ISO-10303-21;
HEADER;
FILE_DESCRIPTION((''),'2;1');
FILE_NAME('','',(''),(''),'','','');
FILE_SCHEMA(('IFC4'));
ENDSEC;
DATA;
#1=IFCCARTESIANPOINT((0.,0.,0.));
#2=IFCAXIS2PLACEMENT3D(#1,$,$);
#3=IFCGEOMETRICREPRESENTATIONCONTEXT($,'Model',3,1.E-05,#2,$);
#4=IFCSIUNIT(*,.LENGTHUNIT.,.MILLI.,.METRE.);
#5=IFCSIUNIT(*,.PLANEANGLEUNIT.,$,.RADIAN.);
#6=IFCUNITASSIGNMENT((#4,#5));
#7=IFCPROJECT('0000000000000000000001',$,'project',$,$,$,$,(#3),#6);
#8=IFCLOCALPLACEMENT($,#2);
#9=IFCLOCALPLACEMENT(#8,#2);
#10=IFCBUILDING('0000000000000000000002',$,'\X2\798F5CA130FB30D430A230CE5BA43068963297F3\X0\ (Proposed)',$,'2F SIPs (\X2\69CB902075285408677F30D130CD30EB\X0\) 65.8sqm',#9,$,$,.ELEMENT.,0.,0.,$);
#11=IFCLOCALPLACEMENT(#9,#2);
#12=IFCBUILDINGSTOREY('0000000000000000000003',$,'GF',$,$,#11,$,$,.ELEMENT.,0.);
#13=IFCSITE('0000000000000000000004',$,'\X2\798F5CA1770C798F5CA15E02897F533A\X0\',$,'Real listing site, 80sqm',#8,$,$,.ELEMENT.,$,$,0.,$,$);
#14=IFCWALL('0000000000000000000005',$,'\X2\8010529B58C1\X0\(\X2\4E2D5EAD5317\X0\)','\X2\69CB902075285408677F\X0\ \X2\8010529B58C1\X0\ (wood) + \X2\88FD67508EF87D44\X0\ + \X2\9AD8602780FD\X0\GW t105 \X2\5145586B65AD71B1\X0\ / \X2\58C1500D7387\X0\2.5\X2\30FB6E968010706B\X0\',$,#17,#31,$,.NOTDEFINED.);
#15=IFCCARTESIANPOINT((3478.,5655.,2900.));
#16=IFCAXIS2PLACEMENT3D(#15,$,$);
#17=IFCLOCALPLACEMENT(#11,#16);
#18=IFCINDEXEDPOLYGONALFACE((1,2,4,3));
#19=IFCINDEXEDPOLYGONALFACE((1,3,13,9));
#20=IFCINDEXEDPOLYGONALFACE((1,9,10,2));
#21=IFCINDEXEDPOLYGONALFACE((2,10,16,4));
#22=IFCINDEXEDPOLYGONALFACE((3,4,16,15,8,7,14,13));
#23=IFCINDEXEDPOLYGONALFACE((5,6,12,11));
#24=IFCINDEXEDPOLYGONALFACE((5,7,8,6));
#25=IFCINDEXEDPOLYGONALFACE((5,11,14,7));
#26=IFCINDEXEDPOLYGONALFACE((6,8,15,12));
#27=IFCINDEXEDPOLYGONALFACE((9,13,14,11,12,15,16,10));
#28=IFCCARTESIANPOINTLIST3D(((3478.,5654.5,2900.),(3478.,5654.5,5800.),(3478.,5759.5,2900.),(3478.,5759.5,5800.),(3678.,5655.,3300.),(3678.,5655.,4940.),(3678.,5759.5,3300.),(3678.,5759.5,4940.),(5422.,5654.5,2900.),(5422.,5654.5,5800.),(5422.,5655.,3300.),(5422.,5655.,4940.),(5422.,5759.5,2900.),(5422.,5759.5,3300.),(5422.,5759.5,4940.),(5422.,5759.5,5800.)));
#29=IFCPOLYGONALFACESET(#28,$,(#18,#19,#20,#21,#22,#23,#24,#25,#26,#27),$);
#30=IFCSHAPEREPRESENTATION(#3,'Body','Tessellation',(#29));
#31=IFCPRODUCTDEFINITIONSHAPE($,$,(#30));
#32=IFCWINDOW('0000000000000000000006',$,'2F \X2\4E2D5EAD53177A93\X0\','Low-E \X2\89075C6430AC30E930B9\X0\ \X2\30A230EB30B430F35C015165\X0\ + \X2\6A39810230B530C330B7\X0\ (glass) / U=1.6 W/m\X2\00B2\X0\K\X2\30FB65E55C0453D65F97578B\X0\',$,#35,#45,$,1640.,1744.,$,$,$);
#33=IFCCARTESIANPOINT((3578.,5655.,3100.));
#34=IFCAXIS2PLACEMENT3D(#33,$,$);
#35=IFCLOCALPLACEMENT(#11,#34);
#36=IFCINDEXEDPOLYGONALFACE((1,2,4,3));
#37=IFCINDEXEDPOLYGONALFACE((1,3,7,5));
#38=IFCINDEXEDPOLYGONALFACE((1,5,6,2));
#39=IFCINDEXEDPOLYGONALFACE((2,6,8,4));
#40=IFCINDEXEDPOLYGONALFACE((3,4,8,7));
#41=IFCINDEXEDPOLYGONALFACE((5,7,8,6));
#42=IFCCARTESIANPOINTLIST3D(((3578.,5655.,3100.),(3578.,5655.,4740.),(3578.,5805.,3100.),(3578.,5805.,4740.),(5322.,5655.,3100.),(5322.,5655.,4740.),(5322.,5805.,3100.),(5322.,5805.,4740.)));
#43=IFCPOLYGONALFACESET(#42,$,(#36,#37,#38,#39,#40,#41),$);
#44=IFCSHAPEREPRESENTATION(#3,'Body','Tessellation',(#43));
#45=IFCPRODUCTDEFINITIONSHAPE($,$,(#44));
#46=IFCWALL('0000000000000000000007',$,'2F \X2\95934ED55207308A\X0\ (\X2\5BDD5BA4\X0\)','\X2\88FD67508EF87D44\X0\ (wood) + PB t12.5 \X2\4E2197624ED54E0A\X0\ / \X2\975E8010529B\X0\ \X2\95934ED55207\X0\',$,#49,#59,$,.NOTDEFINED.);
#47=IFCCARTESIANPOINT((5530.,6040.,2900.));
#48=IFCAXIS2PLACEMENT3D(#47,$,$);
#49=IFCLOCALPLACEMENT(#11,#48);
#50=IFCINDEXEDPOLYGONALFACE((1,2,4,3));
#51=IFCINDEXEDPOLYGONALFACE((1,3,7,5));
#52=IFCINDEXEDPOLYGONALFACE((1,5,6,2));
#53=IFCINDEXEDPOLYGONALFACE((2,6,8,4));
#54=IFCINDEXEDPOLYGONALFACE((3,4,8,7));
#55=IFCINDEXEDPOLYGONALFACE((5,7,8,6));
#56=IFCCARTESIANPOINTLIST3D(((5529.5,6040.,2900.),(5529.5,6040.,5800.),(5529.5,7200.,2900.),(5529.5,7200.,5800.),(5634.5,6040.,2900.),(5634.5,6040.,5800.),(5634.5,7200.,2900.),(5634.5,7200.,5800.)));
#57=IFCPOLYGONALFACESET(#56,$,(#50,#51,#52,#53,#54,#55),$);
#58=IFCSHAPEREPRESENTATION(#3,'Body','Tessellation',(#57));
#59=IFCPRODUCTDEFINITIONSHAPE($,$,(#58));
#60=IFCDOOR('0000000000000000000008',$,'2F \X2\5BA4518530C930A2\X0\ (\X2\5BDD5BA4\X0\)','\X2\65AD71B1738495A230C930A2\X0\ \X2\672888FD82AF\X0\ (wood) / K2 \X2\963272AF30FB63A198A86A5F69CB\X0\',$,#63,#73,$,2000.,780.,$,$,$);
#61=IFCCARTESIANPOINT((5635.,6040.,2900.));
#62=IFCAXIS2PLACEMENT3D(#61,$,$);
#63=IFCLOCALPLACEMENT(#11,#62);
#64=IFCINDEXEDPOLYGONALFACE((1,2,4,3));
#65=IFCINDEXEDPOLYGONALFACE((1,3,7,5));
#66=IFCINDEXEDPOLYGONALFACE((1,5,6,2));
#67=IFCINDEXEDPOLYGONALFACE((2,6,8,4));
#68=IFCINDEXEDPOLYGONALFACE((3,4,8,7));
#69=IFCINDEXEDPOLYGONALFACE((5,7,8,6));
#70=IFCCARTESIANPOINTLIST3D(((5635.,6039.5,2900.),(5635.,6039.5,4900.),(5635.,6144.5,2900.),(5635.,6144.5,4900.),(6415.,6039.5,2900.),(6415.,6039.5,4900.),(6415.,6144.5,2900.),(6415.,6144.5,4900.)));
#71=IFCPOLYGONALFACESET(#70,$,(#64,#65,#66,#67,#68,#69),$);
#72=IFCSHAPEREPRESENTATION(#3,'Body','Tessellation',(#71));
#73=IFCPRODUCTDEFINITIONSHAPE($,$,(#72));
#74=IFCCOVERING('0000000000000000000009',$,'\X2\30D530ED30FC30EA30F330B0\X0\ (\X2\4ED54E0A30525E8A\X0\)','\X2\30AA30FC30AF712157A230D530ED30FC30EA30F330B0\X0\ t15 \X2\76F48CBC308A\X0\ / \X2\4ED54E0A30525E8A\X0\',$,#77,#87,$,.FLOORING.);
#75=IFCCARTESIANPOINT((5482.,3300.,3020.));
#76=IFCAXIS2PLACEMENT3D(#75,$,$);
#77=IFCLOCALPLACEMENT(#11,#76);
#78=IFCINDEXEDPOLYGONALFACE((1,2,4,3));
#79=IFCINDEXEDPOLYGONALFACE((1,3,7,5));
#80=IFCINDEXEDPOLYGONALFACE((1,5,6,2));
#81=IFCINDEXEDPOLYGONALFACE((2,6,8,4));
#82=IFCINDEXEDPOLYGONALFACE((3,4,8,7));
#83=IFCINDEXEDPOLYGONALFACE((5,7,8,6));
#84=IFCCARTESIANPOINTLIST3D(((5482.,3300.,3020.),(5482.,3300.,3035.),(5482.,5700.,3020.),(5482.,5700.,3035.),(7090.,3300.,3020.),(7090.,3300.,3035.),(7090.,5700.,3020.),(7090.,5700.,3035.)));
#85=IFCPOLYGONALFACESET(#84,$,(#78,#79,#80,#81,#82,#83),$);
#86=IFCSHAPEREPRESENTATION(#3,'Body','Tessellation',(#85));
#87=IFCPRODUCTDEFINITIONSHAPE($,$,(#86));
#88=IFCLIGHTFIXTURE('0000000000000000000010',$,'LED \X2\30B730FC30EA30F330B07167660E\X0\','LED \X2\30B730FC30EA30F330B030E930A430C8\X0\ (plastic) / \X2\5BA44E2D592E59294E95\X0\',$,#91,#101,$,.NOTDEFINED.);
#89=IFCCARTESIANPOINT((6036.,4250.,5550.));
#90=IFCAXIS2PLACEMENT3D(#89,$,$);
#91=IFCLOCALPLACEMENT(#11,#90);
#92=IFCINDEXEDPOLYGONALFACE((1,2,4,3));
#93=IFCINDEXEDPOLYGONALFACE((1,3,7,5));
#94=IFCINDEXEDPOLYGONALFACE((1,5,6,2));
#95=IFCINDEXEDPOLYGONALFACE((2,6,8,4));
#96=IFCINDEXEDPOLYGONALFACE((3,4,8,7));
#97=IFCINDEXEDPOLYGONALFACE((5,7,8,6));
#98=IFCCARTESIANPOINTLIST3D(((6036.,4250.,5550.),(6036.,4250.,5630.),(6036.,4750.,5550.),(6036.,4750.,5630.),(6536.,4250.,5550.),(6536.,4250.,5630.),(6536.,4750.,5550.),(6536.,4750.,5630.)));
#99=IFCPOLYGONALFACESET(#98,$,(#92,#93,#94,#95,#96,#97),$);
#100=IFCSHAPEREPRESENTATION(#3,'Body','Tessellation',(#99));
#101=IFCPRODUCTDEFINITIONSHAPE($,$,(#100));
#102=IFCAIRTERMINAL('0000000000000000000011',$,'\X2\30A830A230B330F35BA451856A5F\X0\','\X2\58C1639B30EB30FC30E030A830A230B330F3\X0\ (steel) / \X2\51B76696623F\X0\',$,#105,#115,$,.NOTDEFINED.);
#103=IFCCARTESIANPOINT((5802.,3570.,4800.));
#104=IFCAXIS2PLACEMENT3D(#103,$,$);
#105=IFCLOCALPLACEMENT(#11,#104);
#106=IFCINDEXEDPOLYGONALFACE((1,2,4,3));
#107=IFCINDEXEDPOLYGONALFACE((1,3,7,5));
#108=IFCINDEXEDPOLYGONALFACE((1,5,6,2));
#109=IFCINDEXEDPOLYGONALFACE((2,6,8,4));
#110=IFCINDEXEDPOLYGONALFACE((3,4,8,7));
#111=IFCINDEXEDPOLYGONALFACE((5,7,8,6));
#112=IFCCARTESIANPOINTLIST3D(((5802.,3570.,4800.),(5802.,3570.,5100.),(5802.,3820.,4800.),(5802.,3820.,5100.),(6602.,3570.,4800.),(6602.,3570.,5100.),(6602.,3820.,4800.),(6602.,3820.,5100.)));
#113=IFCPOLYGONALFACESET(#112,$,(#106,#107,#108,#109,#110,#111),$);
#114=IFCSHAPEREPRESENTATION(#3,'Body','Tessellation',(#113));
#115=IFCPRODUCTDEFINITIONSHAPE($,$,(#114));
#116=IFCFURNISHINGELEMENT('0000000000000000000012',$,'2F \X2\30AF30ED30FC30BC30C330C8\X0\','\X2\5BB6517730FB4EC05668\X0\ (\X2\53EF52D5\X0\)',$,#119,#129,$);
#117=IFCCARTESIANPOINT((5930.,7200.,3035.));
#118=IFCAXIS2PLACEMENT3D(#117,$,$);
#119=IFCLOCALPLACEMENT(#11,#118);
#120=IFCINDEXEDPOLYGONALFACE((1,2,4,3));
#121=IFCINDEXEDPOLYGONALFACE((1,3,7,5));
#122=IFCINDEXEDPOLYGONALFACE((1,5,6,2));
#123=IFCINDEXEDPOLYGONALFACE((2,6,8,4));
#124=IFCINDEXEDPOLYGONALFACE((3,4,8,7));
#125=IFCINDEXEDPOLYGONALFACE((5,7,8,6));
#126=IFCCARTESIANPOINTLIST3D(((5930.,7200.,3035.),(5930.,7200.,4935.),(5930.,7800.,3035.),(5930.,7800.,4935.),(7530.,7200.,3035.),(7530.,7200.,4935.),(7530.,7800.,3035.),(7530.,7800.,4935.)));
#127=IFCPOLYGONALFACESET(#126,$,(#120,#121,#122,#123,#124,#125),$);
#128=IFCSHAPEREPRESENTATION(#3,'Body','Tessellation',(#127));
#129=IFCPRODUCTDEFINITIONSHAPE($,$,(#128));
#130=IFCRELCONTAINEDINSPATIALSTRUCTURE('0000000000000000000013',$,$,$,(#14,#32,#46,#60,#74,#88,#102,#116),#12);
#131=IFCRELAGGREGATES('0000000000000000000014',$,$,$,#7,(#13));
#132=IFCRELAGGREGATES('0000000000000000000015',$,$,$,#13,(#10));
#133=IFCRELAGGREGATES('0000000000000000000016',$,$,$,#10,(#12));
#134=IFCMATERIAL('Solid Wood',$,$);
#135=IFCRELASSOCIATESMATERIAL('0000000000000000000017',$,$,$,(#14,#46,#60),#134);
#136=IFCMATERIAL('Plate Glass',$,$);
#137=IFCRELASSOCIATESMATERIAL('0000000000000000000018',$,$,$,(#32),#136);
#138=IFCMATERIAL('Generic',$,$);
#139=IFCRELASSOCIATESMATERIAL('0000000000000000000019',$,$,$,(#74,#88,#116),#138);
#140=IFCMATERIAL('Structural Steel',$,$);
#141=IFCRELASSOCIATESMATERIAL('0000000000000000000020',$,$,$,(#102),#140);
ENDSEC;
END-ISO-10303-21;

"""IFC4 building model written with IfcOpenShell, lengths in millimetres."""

from ifc_helpers import new_model, si_unit, frame, frame_2d, origin, place, context, project, spatial, rectangle, extrude, material, element, fill, save


model = new_model("IFC4")

# Units and contexts
model_context = context("Model", 3, precision=1e-05, world=origin())
ifc_project = project(units=[si_unit("LENGTHUNIT", "METRE", prefix="MILLI"), si_unit("PLANEANGLEUNIT", "RADIAN")], contexts=[model_context])

# Site, building, storey
site_placement = place(None, origin())
site = spatial("IfcSite", under=ifc_project, at=site_placement, Name="福岡県福岡市西区", ObjectType="Real listing site, 80sqm", CompositionType="ELEMENT", RefElevation=0.0)
building_placement = place(site_placement, origin())
building = spatial("IfcBuilding", under=site, at=building_placement, Name="福岡・ピアノ室と防音 (Proposed)", ObjectType="2F SIPs (構造用合板パネル) 65.8sqm", CompositionType="ELEMENT", ElevationOfRefHeight=0.0, ElevationOfTerrain=0.0)
storey_placement = place(building_placement, origin())
storey = spatial("IfcBuildingStorey", under=building, at=storey_placement, Name="GF", CompositionType="ELEMENT", Elevation=0.0)

# Shared definitions
ifc_material_1 = material(Name="Solid Wood")

# Wall, opening, window
wall_1_placement = place(storey_placement, frame((3478.0, 5655.0, 2900.0)))
wall_1 = element("IfcWall", 1, at=wall_1_placement, inside=storey, material=ifc_material_1, Name="耐力壁(中庭北)", Description="構造用合板 耐力壁 (wood) + 製材軸組 + 高性能GW t105 充填断熱 / 壁倍率2.5・準耐火", PredefinedType="NOTDEFINED", context=model_context, shape_type="SweptSolid", body=[
    extrude(rectangle(XDim=1944.0, YDim=105.0, at=frame_2d((972.0, 52.0))), frame((3478.0, 5655.0, 2900.0)), (0.0, 0.0, 1.0), 2900.0),
])
opening_placement = place(storey_placement, frame((3578.0, 5655.0, 3100.0)))
opening = element("IfcOpeningElement", 2, at=opening_placement, cuts=wall_1, PredefinedType="NOTDEFINED", context=model_context, shape_type="SweptSolid", body=[
    extrude(rectangle(XDim=1744.0, YDim=150.0, at=frame_2d((872.0, 75.0))), frame((3578.0, 5655.0, 3100.0)), (0.0, 0.0, 1.0), 1640.0),
])
ifc_material_2 = material(Name="Plate Glass")
window_placement = place(storey_placement, frame((3578.0, 5655.0, 3100.0)))
window = element("IfcWindow", 3, at=window_placement, inside=storey, material=ifc_material_2, Name="2F 中庭北窓", Description="Low-E 複層ガラス アルゴン封入 + 樹脂サッシ (glass) / U=1.6 W/m²K・日射取得型", OverallHeight=1640.0, OverallWidth=1744.0, context=model_context, shape_type="SweptSolid", body=[
    extrude(rectangle(XDim=1744.0, YDim=150.0, at=frame_2d((872.0, 75.0))), frame((3578.0, 5655.0, 3100.0)), (0.0, 0.0, 1.0), 1640.0),
])
fill(opening, window)

# Wall
wall_2_placement = place(storey_placement, frame((5530.0, 6040.0, 2900.0)))
element("IfcWall", 4, at=wall_2_placement, inside=storey, material=ifc_material_1, Name="2F 間仕切り (寝室)", Description="製材軸組 (wood) + PB t12.5 両面仕上 / 非耐力 間仕切", PredefinedType="NOTDEFINED", context=model_context, shape_type="SweptSolid", body=[
    extrude(rectangle(XDim=105.0, YDim=1160.0, at=frame_2d((52.0, 580.0))), frame((5530.0, 6040.0, 2900.0)), (0.0, 0.0, 1.0), 2900.0),
])

# Door
door_placement = place(storey_placement, frame((5635.0, 6040.0, 2900.0)))
element("IfcDoor", 5, at=door_placement, inside=storey, material=ifc_material_1, Name="2F 室内ドア (寝室)", Description="断熱玄関ドア 木製芯 (wood) / K2 防犯・採風機構", OverallHeight=2000.0, OverallWidth=780.0, context=model_context, shape_type="SweptSolid", body=[
    extrude(rectangle(XDim=780.0, YDim=105.0, at=frame_2d((390.0, 52.0))), frame((5635.0, 6040.0, 2900.0)), (0.0, 0.0, 1.0), 2000.0),
])

# Covering
ifc_material_3 = material(Name="Generic")
covering_placement = place(storey_placement, frame((5482.0, 3300.0, 3020.0)))
element("IfcCovering", 6, at=covering_placement, inside=storey, material=ifc_material_3, Name="フローリング (仕上げ床)", Description="オーク無垢フローリング t15 直貼り / 仕上げ床", PredefinedType="FLOORING", context=model_context, shape_type="SweptSolid", body=[
    extrude(rectangle(XDim=1608.0, YDim=2400.0, at=frame_2d((804.0, 1200.0))), frame((5482.0, 3300.0, 3020.0)), (0.0, 0.0, 1.0), 15.0),
])

# Light fixture
light_fixture_placement = place(storey_placement, frame((6036.0, 4250.0, 5550.0)))
element("IfcLightFixture", 7, at=light_fixture_placement, inside=storey, material=ifc_material_3, Name="LED シーリング照明", Description="LED シーリングライト (plastic) / 室中央天井", PredefinedType="NOTDEFINED", context=model_context, shape_type="SweptSolid", body=[
    extrude(rectangle(XDim=500.0, YDim=500.0, at=frame_2d((250.0, 250.0))), frame((6036.0, 4250.0, 5550.0)), (0.0, 0.0, 1.0), 80.0),
])

# Air terminal
ifc_material_4 = material(Name="Structural Steel")
air_terminal_placement = place(storey_placement, frame((5802.0, 3570.0, 4800.0)))
element("IfcAirTerminal", 8, at=air_terminal_placement, inside=storey, material=ifc_material_4, Name="エアコン室内機", Description="壁掛ルームエアコン (steel) / 冷暖房", PredefinedType="NOTDEFINED", context=model_context, shape_type="SweptSolid", body=[
    extrude(rectangle(XDim=800.0, YDim=250.0, at=frame_2d((400.0, 125.0))), frame((5802.0, 3570.0, 4800.0)), (0.0, 0.0, 1.0), 300.0),
])

# Furnishing element
furnishing_placement = place(storey_placement, frame((5930.0, 7200.0, 3035.0)))
element("IfcFurnishingElement", 9, at=furnishing_placement, inside=storey, material=ifc_material_3, Name="2F クローゼット", Description="家具・什器 (可動)", context=model_context, shape_type="SweptSolid", body=[
    extrude(rectangle(XDim=1600.0, YDim=600.0, at=frame_2d((800.0, 300.0))), frame((5930.0, 7200.0, 3035.0)), (0.0, 0.0, 1.0), 1900.0),
])

save(model, "model.ifc")
